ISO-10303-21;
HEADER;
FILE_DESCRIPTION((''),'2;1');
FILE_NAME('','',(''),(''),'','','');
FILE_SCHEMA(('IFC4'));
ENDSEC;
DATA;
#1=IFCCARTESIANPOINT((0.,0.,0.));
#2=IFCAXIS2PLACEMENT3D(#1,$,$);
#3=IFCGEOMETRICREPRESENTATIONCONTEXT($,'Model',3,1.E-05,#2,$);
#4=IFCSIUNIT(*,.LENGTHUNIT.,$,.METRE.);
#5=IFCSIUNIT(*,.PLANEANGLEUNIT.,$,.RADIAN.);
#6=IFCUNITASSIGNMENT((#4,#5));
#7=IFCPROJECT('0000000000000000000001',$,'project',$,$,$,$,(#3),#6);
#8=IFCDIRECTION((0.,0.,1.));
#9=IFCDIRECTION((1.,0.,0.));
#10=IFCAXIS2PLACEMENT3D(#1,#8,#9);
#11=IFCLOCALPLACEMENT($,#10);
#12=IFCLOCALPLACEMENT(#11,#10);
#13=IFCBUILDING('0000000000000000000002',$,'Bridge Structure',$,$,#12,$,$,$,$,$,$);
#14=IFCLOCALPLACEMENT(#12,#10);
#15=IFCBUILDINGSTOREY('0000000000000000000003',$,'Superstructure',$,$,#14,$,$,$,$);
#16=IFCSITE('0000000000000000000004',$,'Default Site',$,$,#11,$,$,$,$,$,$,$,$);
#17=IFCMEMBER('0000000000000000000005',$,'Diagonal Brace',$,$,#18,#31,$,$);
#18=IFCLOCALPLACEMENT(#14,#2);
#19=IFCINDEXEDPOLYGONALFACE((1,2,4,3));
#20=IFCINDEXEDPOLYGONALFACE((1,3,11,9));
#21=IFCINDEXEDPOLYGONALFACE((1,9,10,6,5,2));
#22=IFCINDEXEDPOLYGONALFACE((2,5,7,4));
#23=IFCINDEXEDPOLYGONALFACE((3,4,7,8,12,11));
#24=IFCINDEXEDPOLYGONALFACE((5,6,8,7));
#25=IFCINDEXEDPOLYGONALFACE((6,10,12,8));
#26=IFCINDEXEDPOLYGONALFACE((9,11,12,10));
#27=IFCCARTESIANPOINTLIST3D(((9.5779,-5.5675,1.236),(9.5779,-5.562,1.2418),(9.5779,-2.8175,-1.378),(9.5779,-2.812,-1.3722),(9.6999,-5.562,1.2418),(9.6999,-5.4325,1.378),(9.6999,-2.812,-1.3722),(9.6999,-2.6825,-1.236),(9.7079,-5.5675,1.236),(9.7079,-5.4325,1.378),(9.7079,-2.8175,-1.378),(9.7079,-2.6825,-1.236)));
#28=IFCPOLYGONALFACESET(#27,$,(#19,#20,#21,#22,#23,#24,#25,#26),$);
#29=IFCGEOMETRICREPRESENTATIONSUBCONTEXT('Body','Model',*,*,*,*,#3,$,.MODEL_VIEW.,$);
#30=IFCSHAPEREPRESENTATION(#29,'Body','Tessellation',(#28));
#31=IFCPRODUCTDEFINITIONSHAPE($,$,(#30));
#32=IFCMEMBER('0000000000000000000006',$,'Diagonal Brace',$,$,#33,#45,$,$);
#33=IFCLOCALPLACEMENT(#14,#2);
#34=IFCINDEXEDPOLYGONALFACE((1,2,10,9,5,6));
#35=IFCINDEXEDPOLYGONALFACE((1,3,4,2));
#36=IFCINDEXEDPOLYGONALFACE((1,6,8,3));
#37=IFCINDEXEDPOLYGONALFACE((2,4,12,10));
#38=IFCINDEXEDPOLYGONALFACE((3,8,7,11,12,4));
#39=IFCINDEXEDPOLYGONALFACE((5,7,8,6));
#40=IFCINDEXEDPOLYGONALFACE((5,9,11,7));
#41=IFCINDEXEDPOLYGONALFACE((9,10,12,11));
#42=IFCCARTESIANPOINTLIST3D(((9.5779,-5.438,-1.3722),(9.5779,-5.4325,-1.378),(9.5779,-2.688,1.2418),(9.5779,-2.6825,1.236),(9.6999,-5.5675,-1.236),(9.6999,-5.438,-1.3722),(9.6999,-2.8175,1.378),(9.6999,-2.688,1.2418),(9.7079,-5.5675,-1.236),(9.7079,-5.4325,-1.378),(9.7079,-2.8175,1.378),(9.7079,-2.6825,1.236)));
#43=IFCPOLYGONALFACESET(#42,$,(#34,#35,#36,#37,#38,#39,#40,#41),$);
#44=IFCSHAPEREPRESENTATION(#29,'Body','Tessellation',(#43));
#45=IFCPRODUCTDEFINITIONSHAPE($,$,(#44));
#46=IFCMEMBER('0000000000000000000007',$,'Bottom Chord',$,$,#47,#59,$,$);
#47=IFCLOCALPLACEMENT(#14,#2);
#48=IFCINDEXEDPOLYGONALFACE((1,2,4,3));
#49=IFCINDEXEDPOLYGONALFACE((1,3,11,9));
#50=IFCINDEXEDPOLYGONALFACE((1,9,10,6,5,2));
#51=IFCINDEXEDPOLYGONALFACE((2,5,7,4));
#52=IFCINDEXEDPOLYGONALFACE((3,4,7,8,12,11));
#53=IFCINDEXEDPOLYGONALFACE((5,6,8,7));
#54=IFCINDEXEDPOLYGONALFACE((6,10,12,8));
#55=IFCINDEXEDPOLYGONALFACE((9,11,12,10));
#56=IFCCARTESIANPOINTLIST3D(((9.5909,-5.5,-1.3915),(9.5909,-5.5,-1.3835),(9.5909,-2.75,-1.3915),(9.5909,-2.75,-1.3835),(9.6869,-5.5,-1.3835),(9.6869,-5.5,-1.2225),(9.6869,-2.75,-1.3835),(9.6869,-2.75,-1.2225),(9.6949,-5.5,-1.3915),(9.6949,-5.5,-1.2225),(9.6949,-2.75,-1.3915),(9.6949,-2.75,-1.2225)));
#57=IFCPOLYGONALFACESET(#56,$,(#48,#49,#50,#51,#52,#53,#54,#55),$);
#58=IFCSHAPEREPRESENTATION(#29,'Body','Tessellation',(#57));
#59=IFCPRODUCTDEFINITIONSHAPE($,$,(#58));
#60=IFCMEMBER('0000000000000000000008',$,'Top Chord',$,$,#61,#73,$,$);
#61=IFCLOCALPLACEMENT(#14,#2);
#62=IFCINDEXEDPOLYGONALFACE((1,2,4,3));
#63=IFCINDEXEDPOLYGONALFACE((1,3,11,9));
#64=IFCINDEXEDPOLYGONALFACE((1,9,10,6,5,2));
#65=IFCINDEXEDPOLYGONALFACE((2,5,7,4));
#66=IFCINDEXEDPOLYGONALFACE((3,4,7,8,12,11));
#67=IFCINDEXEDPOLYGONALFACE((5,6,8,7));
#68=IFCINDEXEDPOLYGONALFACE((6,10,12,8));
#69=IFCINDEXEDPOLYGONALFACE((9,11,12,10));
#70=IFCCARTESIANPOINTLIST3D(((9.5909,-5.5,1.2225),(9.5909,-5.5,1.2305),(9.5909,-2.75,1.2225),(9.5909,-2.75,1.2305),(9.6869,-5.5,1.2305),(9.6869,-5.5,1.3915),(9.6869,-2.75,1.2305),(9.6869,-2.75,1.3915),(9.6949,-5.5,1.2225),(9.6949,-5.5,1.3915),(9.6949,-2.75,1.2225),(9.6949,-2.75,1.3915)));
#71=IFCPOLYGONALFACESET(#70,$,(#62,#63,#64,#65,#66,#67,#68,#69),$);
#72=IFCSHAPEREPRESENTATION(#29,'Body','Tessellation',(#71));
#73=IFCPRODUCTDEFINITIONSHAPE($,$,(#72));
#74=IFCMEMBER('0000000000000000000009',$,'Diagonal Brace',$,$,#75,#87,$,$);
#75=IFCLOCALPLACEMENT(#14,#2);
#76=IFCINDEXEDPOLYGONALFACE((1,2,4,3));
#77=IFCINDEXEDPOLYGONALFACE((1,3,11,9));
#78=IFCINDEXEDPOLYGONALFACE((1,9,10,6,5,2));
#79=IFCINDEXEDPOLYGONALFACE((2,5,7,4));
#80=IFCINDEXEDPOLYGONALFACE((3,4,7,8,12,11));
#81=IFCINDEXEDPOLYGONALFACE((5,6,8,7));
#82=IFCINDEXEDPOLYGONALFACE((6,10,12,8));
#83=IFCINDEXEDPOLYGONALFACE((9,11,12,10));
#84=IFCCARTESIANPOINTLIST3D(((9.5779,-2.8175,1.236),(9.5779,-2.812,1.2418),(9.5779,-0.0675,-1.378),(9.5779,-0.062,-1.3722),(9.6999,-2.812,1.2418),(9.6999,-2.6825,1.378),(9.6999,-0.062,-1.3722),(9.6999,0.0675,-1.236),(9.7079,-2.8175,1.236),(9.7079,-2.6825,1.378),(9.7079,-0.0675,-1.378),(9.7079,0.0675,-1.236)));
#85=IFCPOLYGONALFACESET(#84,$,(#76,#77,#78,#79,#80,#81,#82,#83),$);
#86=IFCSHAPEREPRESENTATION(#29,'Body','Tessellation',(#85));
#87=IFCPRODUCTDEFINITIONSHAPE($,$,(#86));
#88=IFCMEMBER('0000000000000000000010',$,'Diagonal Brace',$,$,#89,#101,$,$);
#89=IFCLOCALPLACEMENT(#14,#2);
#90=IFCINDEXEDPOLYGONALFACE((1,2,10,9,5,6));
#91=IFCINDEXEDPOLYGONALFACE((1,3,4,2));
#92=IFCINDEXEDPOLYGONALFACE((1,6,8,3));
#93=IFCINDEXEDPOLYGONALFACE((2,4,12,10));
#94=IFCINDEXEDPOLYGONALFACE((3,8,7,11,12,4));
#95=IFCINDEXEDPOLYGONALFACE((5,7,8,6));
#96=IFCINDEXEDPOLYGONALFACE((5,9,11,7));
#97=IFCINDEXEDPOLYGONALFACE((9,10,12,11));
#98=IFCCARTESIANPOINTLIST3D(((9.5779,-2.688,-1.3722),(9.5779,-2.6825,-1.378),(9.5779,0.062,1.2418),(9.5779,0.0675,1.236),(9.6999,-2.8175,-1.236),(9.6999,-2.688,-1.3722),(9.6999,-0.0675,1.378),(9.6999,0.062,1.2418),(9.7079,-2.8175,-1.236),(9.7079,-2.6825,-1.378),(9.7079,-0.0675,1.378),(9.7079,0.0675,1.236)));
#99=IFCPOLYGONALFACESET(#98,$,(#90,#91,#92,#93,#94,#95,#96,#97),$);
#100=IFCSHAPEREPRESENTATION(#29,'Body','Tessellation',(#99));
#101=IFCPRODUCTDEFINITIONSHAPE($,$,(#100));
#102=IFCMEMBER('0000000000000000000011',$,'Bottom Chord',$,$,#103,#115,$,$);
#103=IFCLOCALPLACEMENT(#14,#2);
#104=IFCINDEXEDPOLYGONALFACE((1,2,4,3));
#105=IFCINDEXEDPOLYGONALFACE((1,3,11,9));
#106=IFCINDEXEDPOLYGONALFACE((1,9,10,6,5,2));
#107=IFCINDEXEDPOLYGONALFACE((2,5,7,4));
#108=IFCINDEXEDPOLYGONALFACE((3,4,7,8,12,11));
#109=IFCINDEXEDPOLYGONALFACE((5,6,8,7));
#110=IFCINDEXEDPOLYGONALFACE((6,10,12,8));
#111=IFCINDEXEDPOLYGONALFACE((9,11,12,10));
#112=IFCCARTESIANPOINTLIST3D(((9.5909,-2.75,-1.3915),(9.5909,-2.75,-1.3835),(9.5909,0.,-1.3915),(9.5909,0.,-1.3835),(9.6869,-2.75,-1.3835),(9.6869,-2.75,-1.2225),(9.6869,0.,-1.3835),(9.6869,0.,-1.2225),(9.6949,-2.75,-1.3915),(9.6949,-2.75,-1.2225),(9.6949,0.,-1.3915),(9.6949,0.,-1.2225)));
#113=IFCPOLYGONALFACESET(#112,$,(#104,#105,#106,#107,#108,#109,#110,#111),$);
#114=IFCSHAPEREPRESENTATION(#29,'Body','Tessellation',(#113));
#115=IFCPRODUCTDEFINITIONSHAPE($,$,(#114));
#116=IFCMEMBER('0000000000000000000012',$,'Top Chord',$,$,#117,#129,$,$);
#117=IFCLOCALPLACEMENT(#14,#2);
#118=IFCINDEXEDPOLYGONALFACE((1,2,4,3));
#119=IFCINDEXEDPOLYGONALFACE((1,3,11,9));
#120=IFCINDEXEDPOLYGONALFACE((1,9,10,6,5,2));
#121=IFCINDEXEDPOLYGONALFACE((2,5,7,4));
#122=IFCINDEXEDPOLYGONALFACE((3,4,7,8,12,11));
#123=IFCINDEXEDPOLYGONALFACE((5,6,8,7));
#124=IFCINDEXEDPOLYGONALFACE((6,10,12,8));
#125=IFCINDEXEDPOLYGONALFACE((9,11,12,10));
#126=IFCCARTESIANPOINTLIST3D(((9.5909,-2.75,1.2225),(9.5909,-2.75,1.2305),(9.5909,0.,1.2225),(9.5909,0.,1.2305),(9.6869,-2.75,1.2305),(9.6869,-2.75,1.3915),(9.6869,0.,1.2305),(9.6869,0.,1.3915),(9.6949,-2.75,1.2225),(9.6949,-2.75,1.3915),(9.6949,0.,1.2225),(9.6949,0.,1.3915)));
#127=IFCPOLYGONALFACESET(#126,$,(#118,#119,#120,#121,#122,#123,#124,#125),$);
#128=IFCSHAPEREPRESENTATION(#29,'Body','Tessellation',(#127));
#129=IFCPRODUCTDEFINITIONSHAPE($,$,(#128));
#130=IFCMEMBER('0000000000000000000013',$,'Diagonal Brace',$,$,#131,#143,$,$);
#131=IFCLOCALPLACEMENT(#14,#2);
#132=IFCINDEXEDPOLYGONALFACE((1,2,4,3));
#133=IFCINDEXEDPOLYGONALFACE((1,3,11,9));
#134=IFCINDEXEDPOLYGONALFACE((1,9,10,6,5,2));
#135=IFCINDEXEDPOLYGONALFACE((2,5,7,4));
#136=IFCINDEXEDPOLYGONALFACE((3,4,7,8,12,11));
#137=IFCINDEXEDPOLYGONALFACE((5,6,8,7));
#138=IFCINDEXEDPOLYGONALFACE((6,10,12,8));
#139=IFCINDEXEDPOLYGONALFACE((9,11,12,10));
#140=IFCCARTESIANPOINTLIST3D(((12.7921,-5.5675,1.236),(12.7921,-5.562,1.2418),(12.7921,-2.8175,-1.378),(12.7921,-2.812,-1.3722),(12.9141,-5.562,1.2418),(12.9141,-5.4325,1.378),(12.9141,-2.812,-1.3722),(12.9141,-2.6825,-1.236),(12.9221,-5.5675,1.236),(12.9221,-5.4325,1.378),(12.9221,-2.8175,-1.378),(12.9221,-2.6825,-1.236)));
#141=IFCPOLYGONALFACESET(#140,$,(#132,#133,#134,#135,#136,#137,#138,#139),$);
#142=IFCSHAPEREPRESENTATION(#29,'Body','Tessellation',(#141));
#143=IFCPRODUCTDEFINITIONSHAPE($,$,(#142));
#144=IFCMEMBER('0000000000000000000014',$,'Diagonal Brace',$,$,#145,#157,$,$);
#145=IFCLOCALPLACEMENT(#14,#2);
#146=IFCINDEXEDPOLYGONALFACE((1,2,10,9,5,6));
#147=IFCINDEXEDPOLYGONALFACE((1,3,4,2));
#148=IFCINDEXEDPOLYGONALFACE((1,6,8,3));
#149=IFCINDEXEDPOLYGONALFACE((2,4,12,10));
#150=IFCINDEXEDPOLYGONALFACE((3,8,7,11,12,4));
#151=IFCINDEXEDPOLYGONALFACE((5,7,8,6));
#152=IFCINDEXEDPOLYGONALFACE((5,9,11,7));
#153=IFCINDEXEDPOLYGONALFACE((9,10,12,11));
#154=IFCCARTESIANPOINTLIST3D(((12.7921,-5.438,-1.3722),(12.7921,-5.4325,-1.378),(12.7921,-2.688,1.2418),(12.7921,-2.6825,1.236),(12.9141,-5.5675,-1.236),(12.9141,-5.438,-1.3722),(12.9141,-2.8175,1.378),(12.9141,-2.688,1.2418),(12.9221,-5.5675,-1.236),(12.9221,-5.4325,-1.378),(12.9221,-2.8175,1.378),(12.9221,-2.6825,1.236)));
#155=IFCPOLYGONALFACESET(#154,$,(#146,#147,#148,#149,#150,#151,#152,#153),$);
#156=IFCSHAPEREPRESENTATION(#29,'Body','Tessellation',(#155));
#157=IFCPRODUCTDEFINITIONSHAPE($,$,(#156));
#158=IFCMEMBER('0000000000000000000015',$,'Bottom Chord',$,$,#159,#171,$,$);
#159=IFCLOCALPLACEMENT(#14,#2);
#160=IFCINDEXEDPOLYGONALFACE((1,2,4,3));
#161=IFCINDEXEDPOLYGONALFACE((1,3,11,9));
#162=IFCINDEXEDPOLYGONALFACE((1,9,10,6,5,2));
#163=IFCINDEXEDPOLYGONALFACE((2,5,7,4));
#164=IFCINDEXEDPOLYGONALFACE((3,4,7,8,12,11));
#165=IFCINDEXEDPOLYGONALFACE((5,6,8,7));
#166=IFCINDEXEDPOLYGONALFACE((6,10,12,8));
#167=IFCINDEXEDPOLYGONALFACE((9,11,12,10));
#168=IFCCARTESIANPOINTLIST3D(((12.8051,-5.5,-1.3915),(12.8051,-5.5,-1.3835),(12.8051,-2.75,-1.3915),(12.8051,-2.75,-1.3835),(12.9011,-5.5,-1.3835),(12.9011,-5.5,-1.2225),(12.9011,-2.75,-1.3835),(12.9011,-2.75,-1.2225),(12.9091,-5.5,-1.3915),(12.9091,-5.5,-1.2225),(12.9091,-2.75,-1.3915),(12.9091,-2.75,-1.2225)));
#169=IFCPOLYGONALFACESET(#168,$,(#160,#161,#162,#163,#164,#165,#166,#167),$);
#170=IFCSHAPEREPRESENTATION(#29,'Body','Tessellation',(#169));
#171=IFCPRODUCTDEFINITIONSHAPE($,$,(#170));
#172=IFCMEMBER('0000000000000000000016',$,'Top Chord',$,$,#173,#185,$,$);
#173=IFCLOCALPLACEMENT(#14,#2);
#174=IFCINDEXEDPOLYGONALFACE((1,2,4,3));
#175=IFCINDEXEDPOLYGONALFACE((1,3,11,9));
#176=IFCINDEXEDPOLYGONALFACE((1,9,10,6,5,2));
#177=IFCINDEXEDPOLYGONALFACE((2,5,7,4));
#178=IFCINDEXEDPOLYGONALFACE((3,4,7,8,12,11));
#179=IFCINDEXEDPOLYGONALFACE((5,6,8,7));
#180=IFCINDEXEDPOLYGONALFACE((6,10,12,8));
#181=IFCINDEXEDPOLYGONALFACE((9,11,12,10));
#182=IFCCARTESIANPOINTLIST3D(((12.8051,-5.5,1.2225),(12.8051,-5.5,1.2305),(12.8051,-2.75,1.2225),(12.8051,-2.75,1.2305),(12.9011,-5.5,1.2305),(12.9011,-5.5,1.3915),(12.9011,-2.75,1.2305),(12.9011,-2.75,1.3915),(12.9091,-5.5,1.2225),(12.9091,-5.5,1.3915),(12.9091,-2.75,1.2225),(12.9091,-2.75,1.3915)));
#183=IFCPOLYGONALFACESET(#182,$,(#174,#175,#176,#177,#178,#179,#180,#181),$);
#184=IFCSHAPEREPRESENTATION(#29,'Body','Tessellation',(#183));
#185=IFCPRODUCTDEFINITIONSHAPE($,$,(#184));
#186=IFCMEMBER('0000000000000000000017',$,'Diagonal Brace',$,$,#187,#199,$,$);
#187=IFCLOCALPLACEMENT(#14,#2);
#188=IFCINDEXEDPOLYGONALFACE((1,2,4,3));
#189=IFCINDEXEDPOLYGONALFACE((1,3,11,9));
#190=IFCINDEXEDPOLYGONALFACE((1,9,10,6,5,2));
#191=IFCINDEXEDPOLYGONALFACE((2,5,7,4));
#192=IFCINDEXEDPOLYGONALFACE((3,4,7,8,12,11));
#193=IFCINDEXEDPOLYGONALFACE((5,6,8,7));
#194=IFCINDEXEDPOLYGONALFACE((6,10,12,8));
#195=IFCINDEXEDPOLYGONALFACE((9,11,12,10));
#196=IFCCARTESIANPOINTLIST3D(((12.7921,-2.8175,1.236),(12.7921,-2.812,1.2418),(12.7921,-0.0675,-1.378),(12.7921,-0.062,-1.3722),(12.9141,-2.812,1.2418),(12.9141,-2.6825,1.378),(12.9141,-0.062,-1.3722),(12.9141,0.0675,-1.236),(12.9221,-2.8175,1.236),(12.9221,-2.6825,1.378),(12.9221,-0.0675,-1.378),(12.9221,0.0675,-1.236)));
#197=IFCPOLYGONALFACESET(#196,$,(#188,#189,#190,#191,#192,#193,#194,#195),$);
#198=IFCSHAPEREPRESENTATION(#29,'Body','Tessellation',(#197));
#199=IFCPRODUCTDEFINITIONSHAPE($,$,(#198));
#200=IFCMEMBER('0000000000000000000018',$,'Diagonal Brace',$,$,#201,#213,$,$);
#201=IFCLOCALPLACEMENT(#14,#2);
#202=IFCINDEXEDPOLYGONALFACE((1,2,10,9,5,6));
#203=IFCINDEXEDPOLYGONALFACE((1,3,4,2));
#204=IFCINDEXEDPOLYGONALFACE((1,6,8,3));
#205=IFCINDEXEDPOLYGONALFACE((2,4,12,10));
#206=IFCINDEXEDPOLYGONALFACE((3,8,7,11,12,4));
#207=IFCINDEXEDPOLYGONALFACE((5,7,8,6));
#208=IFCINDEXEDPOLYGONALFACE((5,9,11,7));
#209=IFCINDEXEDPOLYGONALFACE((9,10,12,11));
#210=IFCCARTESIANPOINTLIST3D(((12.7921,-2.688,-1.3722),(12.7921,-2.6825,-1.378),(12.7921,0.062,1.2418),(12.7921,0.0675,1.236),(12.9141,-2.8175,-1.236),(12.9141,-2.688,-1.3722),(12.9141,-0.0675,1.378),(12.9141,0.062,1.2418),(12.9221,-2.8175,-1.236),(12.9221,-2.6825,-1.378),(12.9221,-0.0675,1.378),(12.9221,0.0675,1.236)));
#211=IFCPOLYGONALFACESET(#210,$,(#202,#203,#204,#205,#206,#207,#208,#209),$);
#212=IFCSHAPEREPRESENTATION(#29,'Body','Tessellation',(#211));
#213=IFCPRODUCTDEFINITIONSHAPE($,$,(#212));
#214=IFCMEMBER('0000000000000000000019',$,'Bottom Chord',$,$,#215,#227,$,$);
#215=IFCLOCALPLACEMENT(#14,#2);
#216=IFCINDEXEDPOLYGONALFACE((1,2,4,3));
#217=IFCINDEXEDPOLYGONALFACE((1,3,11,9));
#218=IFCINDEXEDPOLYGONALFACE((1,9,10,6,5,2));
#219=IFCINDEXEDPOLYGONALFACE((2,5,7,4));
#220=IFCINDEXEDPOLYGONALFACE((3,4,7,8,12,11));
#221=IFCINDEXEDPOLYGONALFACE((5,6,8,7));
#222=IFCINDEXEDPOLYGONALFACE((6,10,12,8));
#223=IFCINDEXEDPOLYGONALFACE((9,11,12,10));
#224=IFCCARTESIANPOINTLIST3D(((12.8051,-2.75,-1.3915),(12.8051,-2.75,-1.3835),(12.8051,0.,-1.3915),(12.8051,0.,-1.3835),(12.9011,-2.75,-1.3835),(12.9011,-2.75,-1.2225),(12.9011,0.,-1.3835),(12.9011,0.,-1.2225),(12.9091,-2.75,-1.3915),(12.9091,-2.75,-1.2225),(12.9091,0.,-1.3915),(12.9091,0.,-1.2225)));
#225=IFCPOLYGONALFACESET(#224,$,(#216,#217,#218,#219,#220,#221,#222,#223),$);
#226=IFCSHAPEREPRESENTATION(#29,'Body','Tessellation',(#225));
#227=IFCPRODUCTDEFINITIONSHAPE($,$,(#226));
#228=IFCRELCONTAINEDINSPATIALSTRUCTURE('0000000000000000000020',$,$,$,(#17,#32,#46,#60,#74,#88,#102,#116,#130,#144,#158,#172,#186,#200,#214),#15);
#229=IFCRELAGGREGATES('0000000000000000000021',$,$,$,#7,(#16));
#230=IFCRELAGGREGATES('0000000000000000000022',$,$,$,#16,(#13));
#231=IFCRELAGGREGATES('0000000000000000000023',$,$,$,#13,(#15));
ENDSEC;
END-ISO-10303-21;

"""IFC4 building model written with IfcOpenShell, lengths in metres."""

from ifc_helpers import new_model, si_unit, frame, origin, origin_with_axes, origin_2d_with_axis, place, context, subcontext, project, spatial, l_section, extrude, element, save


model = new_model("IFC4")

# Units and contexts
model_context = context("Model", 3, precision=1e-05, world=origin())
body_context = subcontext(model_context, "Body", "Model", "MODEL_VIEW")
ifc_project = project(units=[si_unit("LENGTHUNIT", "METRE"), si_unit("PLANEANGLEUNIT", "RADIAN")], contexts=[model_context])

# Site, building, storey
site_placement = place(None, origin_with_axes())
site = spatial("IfcSite", under=ifc_project, at=site_placement, Name="Default Site")
building_placement = place(site_placement, origin_with_axes())
building = spatial("IfcBuilding", under=site, at=building_placement, Name="Bridge Structure")
storey_placement = place(building_placement, origin_with_axes())
storey = spatial("IfcBuildingStorey", under=building, at=storey_placement, Name="Superstructure")

# Members
for number, where, z_axis, x_axis, name in (
    (1, (9.6429, -5.5, 1.307), (0.0, 0.724802, -0.688957), (-1.0, 0.0, 0.0), "Diagonal Brace"),
    (2, (9.6429, -5.5, -1.307), (0.0, 0.724802, 0.688957), (-1.0, 0.0, 0.0), "Diagonal Brace"),
):
    element("IfcMember", number, at=place(storey_placement, frame(where, z_axis=z_axis, x_axis=x_axis)), inside=storey, Name=name, context=body_context, shape_type="SweptSolid", body=[
        extrude(l_section(Depth=0.196, Width=0.13, Thickness=0.008, at=origin_2d_with_axis()), origin_with_axes(), (0.0, 0.0, 1.0), 3.7941),
    ])
for number, where, z_axis, x_axis, name in (
    (3, (9.6429, -5.5, -1.307), (0.0, 1.0, 0.0), (-1.0, 0.0, 0.0), "Bottom Chord"),
    (4, (9.6429, -5.5, 1.307), (0.0, 1.0, 0.0), (-1.0, 0.0, 0.0), "Top Chord"),
):
    element("IfcMember", number, at=place(storey_placement, frame(where, z_axis=z_axis, x_axis=x_axis)), inside=storey, Name=name, context=body_context, shape_type="SweptSolid", body=[
        extrude(l_section(Depth=0.169, Width=0.104, Thickness=0.008, at=origin_2d_with_axis()), origin_with_axes(), (0.0, 0.0, 1.0), 2.75),
    ])
for number, where, z_axis, x_axis, name in (
    (5, (9.6429, -2.75, 1.307), (0.0, 0.724802, -0.688957), (-1.0, 0.0, 0.0), "Diagonal Brace"),
    (6, (9.6429, -2.75, -1.307), (0.0, 0.724802, 0.688957), (-1.0, 0.0, 0.0), "Diagonal Brace"),
):
    element("IfcMember", number, at=place(storey_placement, frame(where, z_axis=z_axis, x_axis=x_axis)), inside=storey, Name=name, context=body_context, shape_type="SweptSolid", body=[
        extrude(l_section(Depth=0.196, Width=0.13, Thickness=0.008, at=origin_2d_with_axis()), origin_with_axes(), (0.0, 0.0, 1.0), 3.7941),
    ])
for number, where, z_axis, x_axis, name in (
    (7, (9.6429, -2.75, -1.307), (0.0, 1.0, 0.0), (-1.0, 0.0, 0.0), "Bottom Chord"),
    (8, (9.6429, -2.75, 1.307), (0.0, 1.0, 0.0), (-1.0, 0.0, 0.0), "Top Chord"),
):
    element("IfcMember", number, at=place(storey_placement, frame(where, z_axis=z_axis, x_axis=x_axis)), inside=storey, Name=name, context=body_context, shape_type="SweptSolid", body=[
        extrude(l_section(Depth=0.169, Width=0.104, Thickness=0.008, at=origin_2d_with_axis()), origin_with_axes(), (0.0, 0.0, 1.0), 2.75),
    ])
for number, where, z_axis, x_axis, name in (
    (9, (12.8571, -5.5, 1.307), (0.0, 0.724802, -0.688957), (-1.0, 0.0, 0.0), "Diagonal Brace"),
    (10, (12.8571, -5.5, -1.307), (0.0, 0.724802, 0.688957), (-1.0, 0.0, 0.0), "Diagonal Brace"),
):
    element("IfcMember", number, at=place(storey_placement, frame(where, z_axis=z_axis, x_axis=x_axis)), inside=storey, Name=name, context=body_context, shape_type="SweptSolid", body=[
        extrude(l_section(Depth=0.196, Width=0.13, Thickness=0.008, at=origin_2d_with_axis()), origin_with_axes(), (0.0, 0.0, 1.0), 3.7941),
    ])
for number, where, z_axis, x_axis, name in (
    (11, (12.8571, -5.5, -1.307), (0.0, 1.0, 0.0), (-1.0, 0.0, 0.0), "Bottom Chord"),
    (12, (12.8571, -5.5, 1.307), (0.0, 1.0, 0.0), (-1.0, 0.0, 0.0), "Top Chord"),
):
    element("IfcMember", number, at=place(storey_placement, frame(where, z_axis=z_axis, x_axis=x_axis)), inside=storey, Name=name, context=body_context, shape_type="SweptSolid", body=[
        extrude(l_section(Depth=0.169, Width=0.104, Thickness=0.008, at=origin_2d_with_axis()), origin_with_axes(), (0.0, 0.0, 1.0), 2.75),
    ])
for number, where, z_axis, x_axis, name in (
    (13, (12.8571, -2.75, 1.307), (0.0, 0.724802, -0.688957), (-1.0, 0.0, 0.0), "Diagonal Brace"),
    (14, (12.8571, -2.75, -1.307), (0.0, 0.724802, 0.688957), (-1.0, 0.0, 0.0), "Diagonal Brace"),
):
    element("IfcMember", number, at=place(storey_placement, frame(where, z_axis=z_axis, x_axis=x_axis)), inside=storey, Name=name, context=body_context, shape_type="SweptSolid", body=[
        extrude(l_section(Depth=0.196, Width=0.13, Thickness=0.008, at=origin_2d_with_axis()), origin_with_axes(), (0.0, 0.0, 1.0), 3.7941),
    ])
for number, where, z_axis, x_axis, name in (
    (15, (12.8571, -2.75, -1.307), (0.0, 1.0, 0.0), (-1.0, 0.0, 0.0), "Bottom Chord"),
):
    element("IfcMember", number, at=place(storey_placement, frame(where, z_axis=z_axis, x_axis=x_axis)), inside=storey, Name=name, context=body_context, shape_type="SweptSolid", body=[
        extrude(l_section(Depth=0.169, Width=0.104, Thickness=0.008, at=origin_2d_with_axis()), origin_with_axes(), (0.0, 0.0, 1.0), 2.75),
    ])

save(model, "model.ifc")
